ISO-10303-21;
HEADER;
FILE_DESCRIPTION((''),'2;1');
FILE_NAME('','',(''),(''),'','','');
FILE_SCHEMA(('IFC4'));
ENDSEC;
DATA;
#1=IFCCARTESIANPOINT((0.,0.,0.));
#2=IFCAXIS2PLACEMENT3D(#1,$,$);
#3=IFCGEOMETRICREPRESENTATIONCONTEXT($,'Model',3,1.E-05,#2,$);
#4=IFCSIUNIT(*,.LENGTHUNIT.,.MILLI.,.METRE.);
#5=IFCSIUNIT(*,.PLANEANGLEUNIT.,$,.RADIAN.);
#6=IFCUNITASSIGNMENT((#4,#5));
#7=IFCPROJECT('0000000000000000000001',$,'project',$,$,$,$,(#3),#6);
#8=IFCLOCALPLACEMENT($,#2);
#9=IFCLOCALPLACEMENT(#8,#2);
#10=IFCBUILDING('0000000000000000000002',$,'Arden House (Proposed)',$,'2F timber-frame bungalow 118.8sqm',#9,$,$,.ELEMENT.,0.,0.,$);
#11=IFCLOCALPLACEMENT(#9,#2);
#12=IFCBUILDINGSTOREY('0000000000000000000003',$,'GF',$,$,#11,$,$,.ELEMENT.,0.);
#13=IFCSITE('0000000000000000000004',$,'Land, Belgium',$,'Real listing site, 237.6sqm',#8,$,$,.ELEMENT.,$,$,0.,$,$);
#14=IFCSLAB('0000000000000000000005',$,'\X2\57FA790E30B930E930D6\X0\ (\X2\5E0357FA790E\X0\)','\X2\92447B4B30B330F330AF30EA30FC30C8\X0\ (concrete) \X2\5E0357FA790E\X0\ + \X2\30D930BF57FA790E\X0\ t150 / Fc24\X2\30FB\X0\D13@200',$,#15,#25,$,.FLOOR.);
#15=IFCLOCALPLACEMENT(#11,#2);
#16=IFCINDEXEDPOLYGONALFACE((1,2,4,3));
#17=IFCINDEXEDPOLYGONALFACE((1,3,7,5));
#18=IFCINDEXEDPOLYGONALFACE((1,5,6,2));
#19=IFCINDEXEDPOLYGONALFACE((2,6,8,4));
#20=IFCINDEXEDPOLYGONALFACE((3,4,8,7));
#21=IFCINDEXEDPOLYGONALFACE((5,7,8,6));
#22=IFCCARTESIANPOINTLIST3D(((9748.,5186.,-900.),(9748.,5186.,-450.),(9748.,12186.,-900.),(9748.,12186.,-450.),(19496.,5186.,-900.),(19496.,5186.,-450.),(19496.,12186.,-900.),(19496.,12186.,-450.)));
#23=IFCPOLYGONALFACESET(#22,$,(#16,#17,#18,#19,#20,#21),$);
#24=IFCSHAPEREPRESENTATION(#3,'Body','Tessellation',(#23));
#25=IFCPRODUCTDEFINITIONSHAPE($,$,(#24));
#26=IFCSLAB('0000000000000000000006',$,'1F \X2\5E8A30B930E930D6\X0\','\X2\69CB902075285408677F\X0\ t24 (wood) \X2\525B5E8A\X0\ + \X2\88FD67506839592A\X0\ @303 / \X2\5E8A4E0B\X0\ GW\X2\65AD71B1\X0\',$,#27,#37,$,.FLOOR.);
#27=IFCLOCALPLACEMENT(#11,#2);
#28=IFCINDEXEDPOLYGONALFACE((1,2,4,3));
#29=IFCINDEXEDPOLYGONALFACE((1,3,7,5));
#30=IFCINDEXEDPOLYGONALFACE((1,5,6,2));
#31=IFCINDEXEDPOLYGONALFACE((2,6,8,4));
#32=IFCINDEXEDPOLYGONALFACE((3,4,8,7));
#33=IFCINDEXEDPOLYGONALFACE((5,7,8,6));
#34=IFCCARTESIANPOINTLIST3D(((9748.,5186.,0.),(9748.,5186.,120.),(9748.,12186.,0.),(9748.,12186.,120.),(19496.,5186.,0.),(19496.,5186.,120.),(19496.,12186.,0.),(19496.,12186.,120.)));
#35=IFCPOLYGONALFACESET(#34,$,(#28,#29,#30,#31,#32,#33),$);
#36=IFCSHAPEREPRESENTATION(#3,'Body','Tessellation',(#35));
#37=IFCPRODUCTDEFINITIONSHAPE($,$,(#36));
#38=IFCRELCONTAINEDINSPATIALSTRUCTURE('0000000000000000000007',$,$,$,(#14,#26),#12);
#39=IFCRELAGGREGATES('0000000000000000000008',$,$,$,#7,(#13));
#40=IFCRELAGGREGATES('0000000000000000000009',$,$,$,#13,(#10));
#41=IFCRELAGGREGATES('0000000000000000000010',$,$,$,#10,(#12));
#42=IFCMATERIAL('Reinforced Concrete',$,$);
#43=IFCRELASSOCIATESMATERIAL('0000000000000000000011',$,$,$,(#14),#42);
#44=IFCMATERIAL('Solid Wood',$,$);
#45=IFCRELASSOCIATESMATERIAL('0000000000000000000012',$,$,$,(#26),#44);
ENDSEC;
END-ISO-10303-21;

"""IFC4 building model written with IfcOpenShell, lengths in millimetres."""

from ifc_helpers import new_model, si_unit, frame, frame_2d, origin, place, context, project, spatial, rectangle, extrude, material, element, save


model = new_model("IFC4")

# Units and contexts
model_context = context("Model", 3, precision=1e-05, world=origin())
ifc_project = project(units=[si_unit("LENGTHUNIT", "METRE", prefix="MILLI"), si_unit("PLANEANGLEUNIT", "RADIAN")], contexts=[model_context])

# Site, building, storey
site_placement = place(None, origin())
site = spatial("IfcSite", under=ifc_project, at=site_placement, Name="Land, Belgium", ObjectType="Real listing site, 237.6sqm", CompositionType="ELEMENT", RefElevation=0.0)
building_placement = place(site_placement, origin())
building = spatial("IfcBuilding", under=site, at=building_placement, Name="Arden House (Proposed)", ObjectType="2F timber-frame bungalow 118.8sqm", CompositionType="ELEMENT", ElevationOfRefHeight=0.0, ElevationOfTerrain=0.0)
storey_placement = place(building_placement, origin())
storey = spatial("IfcBuildingStorey", under=building, at=storey_placement, Name="GF", CompositionType="ELEMENT", Elevation=0.0)

# Slabs
ifc_material_1 = material(Name="Reinforced Concrete")
slab_1_placement = place(storey_placement, frame((4874.0, 2593.0, -450.0)))
element("IfcSlab", 1, at=slab_1_placement, inside=storey, material=ifc_material_1, Name="基礎スラブ (布基礎)", Description="鉄筋コンクリート (concrete) 布基礎 + ベタ基礎 t150 / Fc24・D13@200", PredefinedType="FLOOR", context=model_context, shape_type="SweptSolid", body=[
    extrude(rectangle(XDim=9748.0, YDim=7000.0, at=frame_2d((4874.0, 3500.0))), frame((4874.0, 2593.0, -450.0)), (0.0, 0.0, 1.0), 450.0),
])
ifc_material_2 = material(Name="Solid Wood")
slab_2_placement = place(storey_placement, frame((4874.0, 2593.0, 0.0)))
element("IfcSlab", 2, at=slab_2_placement, inside=storey, material=ifc_material_2, Name="1F 床スラブ", Description="構造用合板 t24 (wood) 剛床 + 製材根太 @303 / 床下 GW断熱", PredefinedType="FLOOR", context=model_context, shape_type="SweptSolid", body=[
    extrude(rectangle(XDim=9748.0, YDim=7000.0, at=frame_2d((4874.0, 3500.0))), frame((4874.0, 2593.0, 0.0)), (0.0, 0.0, 1.0), 120.0),
])

save(model, "model.ifc")
